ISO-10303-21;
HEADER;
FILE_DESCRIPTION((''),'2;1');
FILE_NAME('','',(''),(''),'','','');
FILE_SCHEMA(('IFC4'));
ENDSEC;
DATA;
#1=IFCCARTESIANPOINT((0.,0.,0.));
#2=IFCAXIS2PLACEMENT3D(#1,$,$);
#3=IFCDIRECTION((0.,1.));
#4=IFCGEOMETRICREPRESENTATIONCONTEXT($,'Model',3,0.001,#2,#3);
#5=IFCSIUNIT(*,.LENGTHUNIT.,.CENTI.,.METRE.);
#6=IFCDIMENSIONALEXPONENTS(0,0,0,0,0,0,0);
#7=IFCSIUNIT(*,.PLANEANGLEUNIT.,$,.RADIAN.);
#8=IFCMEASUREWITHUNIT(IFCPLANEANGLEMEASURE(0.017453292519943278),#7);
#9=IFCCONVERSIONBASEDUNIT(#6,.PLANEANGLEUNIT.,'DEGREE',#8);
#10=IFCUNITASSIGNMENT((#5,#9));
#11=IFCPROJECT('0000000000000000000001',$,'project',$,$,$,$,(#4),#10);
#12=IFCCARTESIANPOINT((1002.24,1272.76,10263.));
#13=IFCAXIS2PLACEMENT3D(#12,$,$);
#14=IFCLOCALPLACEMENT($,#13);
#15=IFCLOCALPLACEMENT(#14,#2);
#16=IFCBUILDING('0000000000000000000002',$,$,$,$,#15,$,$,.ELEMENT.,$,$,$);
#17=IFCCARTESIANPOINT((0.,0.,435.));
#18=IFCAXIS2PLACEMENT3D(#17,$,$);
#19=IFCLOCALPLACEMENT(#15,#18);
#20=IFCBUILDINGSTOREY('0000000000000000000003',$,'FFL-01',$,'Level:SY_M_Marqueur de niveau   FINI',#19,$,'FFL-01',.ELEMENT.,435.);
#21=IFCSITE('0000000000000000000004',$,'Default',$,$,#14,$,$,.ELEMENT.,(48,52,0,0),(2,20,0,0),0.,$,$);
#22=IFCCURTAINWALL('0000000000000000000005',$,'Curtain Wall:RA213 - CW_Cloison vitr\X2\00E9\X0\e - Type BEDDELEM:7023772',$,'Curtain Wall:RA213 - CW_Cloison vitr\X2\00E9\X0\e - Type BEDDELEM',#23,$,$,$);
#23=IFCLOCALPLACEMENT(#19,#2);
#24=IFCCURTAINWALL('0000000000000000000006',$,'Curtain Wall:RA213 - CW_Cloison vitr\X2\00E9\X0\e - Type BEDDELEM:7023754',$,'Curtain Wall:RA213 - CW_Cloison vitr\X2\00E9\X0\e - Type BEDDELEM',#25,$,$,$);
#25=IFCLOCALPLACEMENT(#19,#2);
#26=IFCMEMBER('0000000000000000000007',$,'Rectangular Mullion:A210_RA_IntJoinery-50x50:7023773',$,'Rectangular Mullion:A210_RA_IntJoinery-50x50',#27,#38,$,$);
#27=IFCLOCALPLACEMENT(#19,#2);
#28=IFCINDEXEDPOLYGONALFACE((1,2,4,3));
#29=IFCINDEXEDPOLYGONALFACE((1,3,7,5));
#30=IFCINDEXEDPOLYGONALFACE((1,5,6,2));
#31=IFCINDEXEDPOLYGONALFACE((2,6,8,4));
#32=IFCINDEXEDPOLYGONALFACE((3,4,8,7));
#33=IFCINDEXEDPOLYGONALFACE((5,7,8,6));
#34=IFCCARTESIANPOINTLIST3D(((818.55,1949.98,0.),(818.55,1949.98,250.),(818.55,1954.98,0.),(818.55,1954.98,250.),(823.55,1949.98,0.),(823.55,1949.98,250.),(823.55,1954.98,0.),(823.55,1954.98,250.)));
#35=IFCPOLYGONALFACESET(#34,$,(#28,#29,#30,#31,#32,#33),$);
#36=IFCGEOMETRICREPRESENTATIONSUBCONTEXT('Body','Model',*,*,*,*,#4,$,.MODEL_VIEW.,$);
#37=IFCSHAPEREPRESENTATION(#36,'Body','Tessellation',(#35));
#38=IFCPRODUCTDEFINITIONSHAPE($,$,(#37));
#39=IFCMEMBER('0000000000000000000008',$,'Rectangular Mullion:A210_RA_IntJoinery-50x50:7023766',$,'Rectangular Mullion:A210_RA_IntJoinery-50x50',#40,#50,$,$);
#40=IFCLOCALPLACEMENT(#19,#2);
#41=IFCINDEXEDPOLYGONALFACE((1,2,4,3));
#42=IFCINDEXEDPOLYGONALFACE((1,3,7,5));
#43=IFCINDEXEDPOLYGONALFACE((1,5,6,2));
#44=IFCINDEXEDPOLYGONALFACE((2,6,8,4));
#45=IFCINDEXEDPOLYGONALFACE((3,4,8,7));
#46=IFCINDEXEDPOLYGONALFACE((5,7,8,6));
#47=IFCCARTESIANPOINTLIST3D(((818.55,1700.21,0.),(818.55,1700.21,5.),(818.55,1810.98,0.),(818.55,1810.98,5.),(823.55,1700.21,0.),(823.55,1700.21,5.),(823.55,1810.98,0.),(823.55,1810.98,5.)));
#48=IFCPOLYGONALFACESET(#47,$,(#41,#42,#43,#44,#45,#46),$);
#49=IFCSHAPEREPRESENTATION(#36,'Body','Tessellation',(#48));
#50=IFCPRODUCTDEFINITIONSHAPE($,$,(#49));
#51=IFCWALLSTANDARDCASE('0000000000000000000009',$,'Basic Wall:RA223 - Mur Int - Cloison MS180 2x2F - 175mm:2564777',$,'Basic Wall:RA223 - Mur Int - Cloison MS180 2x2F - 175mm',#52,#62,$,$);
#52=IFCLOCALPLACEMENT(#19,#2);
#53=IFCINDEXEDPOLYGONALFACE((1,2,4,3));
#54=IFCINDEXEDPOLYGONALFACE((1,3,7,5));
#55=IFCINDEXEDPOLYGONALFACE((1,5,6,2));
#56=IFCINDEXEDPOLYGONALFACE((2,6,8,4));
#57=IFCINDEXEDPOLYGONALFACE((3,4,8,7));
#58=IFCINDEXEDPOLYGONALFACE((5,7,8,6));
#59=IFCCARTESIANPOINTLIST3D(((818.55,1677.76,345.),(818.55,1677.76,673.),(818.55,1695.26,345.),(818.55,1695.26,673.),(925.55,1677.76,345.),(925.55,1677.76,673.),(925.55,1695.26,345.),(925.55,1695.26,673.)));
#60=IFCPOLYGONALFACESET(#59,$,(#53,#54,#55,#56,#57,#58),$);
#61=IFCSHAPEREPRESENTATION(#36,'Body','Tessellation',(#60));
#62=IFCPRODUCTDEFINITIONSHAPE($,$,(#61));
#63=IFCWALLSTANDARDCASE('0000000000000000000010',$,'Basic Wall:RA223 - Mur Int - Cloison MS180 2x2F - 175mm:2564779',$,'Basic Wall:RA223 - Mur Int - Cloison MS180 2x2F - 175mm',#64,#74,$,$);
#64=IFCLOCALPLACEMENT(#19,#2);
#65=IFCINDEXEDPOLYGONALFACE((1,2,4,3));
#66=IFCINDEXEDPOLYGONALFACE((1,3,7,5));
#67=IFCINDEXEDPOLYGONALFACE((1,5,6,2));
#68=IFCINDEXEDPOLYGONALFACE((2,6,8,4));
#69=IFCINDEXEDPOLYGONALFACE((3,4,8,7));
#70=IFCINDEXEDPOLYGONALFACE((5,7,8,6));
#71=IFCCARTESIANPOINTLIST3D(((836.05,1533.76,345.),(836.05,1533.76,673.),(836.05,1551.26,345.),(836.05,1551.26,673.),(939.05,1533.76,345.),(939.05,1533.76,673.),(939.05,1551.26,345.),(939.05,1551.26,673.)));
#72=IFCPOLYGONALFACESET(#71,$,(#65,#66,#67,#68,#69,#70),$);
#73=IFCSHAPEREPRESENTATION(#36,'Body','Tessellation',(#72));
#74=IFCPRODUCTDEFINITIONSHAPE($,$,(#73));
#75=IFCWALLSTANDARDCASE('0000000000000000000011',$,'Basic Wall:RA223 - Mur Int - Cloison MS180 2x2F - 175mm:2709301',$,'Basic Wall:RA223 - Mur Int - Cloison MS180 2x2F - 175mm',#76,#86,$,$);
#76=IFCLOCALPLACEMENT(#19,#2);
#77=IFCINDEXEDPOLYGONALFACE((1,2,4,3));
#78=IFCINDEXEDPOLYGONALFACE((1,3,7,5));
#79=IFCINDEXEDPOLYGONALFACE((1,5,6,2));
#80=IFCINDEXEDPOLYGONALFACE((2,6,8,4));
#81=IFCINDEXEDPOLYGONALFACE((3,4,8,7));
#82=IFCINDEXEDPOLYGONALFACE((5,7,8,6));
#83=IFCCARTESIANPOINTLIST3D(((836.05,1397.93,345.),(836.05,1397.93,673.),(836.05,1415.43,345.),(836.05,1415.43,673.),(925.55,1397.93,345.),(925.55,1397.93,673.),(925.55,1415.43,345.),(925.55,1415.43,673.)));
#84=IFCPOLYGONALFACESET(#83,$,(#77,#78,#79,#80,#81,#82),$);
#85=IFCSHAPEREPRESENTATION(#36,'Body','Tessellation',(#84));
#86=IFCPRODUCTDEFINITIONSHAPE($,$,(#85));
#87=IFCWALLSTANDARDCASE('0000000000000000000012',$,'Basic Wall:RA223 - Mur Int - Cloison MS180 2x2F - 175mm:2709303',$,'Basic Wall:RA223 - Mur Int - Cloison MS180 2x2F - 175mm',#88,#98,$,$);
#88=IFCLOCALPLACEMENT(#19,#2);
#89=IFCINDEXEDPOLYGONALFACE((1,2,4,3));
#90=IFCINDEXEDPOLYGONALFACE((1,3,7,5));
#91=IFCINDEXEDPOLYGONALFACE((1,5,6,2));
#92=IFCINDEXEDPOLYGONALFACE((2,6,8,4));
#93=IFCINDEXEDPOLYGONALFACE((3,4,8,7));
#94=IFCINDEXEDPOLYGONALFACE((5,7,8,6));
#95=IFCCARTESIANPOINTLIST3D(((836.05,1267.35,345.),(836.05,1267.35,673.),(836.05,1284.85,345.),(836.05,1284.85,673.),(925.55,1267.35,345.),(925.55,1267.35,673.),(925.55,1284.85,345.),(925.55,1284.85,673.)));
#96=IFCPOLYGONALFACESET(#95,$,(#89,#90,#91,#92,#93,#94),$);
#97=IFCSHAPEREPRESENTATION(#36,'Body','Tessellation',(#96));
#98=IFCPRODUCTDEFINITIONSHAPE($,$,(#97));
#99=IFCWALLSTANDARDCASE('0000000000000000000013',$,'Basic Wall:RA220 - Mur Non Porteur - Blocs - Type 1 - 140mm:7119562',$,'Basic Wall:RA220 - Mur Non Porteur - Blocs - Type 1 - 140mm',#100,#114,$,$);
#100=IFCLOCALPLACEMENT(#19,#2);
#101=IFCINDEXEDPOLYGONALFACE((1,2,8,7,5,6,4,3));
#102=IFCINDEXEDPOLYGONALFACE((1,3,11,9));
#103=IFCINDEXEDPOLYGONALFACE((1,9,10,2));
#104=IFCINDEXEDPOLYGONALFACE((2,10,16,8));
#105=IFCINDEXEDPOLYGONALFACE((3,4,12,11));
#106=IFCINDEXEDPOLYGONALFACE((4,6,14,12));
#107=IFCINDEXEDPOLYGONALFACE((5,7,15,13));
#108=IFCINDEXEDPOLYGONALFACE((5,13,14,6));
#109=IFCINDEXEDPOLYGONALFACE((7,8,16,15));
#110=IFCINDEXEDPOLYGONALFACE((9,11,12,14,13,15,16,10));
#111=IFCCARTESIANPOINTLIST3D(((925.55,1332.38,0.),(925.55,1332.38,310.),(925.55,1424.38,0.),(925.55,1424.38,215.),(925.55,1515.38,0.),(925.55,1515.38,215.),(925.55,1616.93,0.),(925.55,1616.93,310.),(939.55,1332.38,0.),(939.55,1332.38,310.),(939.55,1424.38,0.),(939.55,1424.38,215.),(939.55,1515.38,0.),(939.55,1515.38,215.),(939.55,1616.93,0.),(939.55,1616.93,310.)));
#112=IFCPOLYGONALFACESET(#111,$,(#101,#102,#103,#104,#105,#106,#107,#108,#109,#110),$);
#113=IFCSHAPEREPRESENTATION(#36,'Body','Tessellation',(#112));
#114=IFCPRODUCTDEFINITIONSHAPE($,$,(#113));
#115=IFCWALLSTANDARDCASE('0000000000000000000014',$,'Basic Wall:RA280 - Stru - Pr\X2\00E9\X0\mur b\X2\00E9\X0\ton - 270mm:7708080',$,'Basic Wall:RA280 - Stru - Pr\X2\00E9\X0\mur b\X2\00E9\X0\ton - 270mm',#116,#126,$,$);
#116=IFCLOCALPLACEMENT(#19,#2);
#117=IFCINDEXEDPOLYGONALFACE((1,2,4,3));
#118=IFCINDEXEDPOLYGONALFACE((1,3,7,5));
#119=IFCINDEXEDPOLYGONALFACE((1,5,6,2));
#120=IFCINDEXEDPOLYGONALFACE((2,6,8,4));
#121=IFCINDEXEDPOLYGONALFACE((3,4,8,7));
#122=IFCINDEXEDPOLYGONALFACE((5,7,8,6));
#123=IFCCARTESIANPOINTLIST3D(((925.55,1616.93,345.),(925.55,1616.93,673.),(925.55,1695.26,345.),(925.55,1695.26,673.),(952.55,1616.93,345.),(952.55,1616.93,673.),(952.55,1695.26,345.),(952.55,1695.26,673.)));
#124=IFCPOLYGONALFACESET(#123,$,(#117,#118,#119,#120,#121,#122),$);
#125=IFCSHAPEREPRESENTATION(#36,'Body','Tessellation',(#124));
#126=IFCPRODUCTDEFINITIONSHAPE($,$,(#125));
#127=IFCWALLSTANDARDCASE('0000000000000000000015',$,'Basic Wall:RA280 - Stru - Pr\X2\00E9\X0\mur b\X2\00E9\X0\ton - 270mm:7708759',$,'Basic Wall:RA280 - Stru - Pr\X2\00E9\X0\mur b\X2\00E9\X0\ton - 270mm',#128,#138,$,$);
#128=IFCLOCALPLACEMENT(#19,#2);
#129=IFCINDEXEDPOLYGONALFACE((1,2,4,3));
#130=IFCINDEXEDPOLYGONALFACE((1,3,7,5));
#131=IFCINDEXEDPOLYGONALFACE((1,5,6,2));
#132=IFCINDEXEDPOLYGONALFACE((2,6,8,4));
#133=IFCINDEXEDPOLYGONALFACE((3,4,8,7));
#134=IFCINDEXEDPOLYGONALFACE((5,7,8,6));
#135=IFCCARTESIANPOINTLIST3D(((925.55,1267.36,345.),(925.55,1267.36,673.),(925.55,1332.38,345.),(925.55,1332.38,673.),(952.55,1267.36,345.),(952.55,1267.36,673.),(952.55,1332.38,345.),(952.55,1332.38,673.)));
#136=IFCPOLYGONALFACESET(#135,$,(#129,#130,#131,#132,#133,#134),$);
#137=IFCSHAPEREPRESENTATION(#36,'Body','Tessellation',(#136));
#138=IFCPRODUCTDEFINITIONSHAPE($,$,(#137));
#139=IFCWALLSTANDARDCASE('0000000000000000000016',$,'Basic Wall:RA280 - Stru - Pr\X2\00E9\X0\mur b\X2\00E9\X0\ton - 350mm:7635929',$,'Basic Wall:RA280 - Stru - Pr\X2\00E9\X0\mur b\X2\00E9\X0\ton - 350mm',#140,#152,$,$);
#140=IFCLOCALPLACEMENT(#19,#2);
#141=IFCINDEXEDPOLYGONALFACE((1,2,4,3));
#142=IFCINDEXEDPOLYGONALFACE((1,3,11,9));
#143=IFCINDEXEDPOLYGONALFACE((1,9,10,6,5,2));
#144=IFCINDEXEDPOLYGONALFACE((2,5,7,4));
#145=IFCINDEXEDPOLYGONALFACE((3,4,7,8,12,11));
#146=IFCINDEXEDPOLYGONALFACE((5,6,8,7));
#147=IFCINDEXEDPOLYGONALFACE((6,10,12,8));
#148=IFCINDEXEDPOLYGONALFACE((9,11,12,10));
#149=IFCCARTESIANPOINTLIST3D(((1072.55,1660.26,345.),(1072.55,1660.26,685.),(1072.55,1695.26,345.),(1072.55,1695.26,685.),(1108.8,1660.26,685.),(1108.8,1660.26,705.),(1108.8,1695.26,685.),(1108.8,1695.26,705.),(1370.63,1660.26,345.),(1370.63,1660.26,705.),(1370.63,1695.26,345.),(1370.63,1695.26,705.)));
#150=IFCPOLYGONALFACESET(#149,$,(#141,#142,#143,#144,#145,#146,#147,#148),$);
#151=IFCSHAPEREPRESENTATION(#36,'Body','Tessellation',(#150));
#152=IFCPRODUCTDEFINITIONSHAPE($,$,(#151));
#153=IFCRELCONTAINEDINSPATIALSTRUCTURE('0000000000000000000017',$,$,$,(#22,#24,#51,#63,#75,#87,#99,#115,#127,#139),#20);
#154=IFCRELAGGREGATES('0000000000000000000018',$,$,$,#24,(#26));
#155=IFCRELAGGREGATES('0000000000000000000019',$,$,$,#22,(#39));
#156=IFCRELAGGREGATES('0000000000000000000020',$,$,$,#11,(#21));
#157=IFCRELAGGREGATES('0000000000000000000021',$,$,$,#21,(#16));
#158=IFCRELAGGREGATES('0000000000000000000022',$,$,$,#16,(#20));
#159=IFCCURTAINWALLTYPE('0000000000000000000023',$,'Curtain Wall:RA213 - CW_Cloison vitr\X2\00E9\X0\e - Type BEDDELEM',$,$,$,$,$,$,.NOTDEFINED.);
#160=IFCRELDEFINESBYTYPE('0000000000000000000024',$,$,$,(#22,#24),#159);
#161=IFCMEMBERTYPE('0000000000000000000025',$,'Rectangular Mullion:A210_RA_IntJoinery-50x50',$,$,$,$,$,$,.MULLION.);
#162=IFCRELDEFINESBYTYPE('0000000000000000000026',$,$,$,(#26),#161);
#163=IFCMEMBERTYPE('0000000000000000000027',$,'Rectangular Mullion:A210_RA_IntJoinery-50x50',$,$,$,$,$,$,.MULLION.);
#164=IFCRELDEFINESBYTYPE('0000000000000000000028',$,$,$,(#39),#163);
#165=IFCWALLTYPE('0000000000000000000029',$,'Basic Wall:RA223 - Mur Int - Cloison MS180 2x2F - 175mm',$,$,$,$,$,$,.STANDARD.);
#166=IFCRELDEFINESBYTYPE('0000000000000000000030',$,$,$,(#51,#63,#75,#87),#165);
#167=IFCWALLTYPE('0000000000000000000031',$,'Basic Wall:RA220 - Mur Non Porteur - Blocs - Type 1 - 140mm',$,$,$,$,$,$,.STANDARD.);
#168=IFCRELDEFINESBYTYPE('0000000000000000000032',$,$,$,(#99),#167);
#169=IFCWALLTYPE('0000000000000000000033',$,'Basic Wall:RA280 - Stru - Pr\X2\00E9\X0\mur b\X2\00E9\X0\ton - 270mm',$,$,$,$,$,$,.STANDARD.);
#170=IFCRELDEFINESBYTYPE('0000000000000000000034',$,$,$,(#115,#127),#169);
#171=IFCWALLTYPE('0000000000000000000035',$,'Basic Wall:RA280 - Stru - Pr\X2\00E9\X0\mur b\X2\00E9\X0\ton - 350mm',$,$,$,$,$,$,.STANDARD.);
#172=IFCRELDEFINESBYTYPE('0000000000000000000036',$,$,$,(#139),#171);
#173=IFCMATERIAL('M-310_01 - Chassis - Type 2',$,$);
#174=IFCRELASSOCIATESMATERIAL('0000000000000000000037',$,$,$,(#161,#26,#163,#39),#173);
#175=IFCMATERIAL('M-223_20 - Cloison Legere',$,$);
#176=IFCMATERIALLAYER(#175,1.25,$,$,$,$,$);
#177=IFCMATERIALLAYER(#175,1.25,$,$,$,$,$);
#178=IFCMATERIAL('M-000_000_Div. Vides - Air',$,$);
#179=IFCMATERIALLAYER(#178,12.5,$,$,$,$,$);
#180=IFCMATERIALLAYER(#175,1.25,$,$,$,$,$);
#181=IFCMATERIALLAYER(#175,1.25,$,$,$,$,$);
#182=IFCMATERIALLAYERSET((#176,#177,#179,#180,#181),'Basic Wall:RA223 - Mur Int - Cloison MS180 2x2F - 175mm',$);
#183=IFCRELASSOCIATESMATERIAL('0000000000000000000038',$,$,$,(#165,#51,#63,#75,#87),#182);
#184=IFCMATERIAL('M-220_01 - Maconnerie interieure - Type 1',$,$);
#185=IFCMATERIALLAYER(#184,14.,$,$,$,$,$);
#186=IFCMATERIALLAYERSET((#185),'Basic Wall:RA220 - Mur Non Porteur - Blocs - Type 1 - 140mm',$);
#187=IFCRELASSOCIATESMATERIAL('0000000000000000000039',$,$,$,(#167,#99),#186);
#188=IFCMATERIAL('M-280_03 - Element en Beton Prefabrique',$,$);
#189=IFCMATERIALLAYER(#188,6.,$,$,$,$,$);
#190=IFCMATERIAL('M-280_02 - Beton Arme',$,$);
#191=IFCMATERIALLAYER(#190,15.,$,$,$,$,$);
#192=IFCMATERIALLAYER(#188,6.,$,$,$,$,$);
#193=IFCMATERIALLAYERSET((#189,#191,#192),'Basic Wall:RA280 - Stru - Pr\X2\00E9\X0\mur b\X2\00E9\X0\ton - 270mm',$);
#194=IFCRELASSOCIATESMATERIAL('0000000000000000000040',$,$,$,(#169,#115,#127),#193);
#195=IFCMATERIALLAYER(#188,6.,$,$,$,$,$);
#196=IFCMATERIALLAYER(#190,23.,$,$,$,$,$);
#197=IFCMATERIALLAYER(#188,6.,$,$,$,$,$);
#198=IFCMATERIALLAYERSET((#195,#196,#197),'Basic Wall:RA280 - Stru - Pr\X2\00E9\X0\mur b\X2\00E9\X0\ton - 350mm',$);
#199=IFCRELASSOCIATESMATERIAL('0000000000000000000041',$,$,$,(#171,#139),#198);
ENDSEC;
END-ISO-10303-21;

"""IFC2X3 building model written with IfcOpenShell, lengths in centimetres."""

from ifc_helpers import new_model, entity, si_unit, converted_unit, direction, frame, frame_2d, origin, origin_2d_with_axis, place, context, subcontext, project, spatial, polyline, rectangle, extrude, clip, bounded_halfspace, source, transform, mapped, material, layer, layer_set, layer_usage, type_object, type_shapes, element, aggregate, save


model = new_model("IFC2X3")

# Units and contexts
model_context = context("Model", 3, precision=0.001, world=origin(), true_north=direction((0.0, 1.0)))
body_context = subcontext(model_context, "Body", "Model", "MODEL_VIEW")
ifc_project = project(units=[si_unit("LENGTHUNIT", "METRE", prefix="CENTI"), converted_unit("PLANEANGLEUNIT", "DEGREE", entity("IfcPlaneAngleMeasure", 0.017453292519943278), si_unit("PLANEANGLEUNIT", "RADIAN"), dimensions=[0, 0, 0, 0, 0, 0, 0])], contexts=[model_context])

# Site, building, storey
site_placement = place(None, frame((1002.24, 1272.76, 10263.0)))
site = spatial("IfcSite", under=ifc_project, at=site_placement, Name="Default", CompositionType="ELEMENT", RefLatitude=(48, 52, 0, 0), RefLongitude=(2, 20, 0, 0), RefElevation=0.0)
building_placement = place(site_placement, origin())
building = spatial("IfcBuilding", under=site, at=building_placement, CompositionType="ELEMENT")
storey_placement = place(building_placement, frame((0.0, 0.0, 435.0)))
storey = spatial("IfcBuildingStorey", under=building, at=storey_placement, Name="FFL-01", ObjectType="Level:SY_M_Marqueur de niveau   FINI", LongName="FFL-01", CompositionType="ELEMENT", Elevation=435.0)

# Curtain wall
curtain_wall_type_1 = type_object("IfcCurtainWallType", Name="Curtain Wall:RA213 - CW_Cloison vitrée - Type BEDDELEM", PredefinedType="NOTDEFINED")
curtain_wall_1_placement = place(storey_placement, frame((0.0, 0.0, -435.0)))
curtain_wall_1 = element("IfcCurtainWall", 1, at=curtain_wall_1_placement, inside=storey, type_object=curtain_wall_type_1, Name="Curtain Wall:RA213 - CW_Cloison vitrée - Type BEDDELEM:7023772", ObjectType="Curtain Wall:RA213 - CW_Cloison vitrée - Type BEDDELEM")
ifc_material_1 = material(Name="M-310_01 - Chassis - Type 2")

# Shared definitions
ifc_material_2 = material(Name="M-280_02 - Beton Arme")

# Curtain wall, member
curtain_wall_2_placement = place(storey_placement, frame((0.0, 0.0, -435.0)))
curtain_wall_2 = element("IfcCurtainWall", 2, at=curtain_wall_2_placement, inside=storey, type_object=curtain_wall_type_1, Name="Curtain Wall:RA213 - CW_Cloison vitrée - Type BEDDELEM:7023754", ObjectType="Curtain Wall:RA213 - CW_Cloison vitrée - Type BEDDELEM")
member_type_1 = type_object("IfcMemberType", Name="Rectangular Mullion:A210_RA_IntJoinery-50x50", PredefinedType="MULLION", material=ifc_material_1)
shared_shape_1 = source(origin(), body_context, "Body", "SweptSolid", [
    extrude(rectangle(XDim=5.0, YDim=5.0, at=origin_2d_with_axis()), frame((-2.5, -2.5, -250.0), z_axis=(0.0, 0.0, 1.0), x_axis=(-1.0, 0.0, 0.0)), (0.0, 0.0, 1.0), 250.0),
])
type_shapes(member_type_1, [shared_shape_1])
member_1_placement = place(curtain_wall_2_placement, frame((818.55, 1949.98, 435.0), z_axis=(0.0, 0.0, -1.0), x_axis=(0.0, -1.0, 0.0)))
member_1 = element("IfcMember", 3, at=member_1_placement, type_object=member_type_1, material=ifc_material_1, Name="Rectangular Mullion:A210_RA_IntJoinery-50x50:7023773", ObjectType="Rectangular Mullion:A210_RA_IntJoinery-50x50", context=body_context, shape_type="MappedRepresentation", body=[
    mapped(shared_shape_1, transform((0.0, 0.0, 0.0), scale=1.0)),
])
aggregate(curtain_wall_2, [member_1])

# Member
member_type_2 = type_object("IfcMemberType", Name="Rectangular Mullion:A210_RA_IntJoinery-50x50", PredefinedType="MULLION", material=ifc_material_1)
shared_shape_2 = source(origin(), body_context, "Body", "SweptSolid", [
    extrude(rectangle(XDim=5.0, YDim=5.0, at=origin_2d_with_axis()), frame((-2.5, -2.5, -110.77), z_axis=(0.0, 0.0, 1.0), x_axis=(-1.0, 0.0, 0.0)), (0.0, 0.0, 1.0), 110.77),
])
type_shapes(member_type_2, [shared_shape_2])
member_2_placement = place(curtain_wall_1_placement, frame((818.55, 1810.98, 435.0), z_axis=(0.0, 1.0, 0.0), x_axis=(0.0, 0.0, -1.0)))
member_2 = element("IfcMember", 4, at=member_2_placement, type_object=member_type_2, material=ifc_material_1, Name="Rectangular Mullion:A210_RA_IntJoinery-50x50:7023766", ObjectType="Rectangular Mullion:A210_RA_IntJoinery-50x50", context=body_context, shape_type="MappedRepresentation", body=[
    mapped(shared_shape_2, transform((0.0, 0.0, 0.0), scale=1.0)),
])

# Walls
ifc_material_3 = material(Name="M-223_20 - Cloison Legere")
ifc_layer_1 = layer(ifc_material_3, 1.25)
ifc_layer_2 = layer(ifc_material_3, 1.25)
ifc_material_4 = material(Name="M-000_000_Div. Vides - Air")
ifc_layer_3 = layer(ifc_material_4, 12.5)
ifc_layer_4 = layer(ifc_material_3, 1.25)
ifc_layer_5 = layer(ifc_material_3, 1.25)
ifc_layer_set_1 = layer_set([ifc_layer_1, ifc_layer_2, ifc_layer_3, ifc_layer_4, ifc_layer_5], Name="Basic Wall:RA223 - Mur Int - Cloison MS180 2x2F - 175mm")
ifc_layer_usage_1 = layer_usage(ifc_layer_set_1, "AXIS2", "NEGATIVE", 8.75)
wall_type_1 = type_object("IfcWallType", Name="Basic Wall:RA223 - Mur Int - Cloison MS180 2x2F - 175mm", PredefinedType="STANDARD", material=ifc_layer_set_1)
wall_1_placement = place(storey_placement, frame((818.55, 1686.51, 345.0)))
element("IfcWallStandardCase", 5, at=wall_1_placement, inside=storey, type_object=wall_type_1, material=ifc_layer_usage_1, Name="Basic Wall:RA223 - Mur Int - Cloison MS180 2x2F - 175mm:2564777", ObjectType="Basic Wall:RA223 - Mur Int - Cloison MS180 2x2F - 175mm", context=body_context, shape_type="Clipping", body=[
    clip(extrude(rectangle(XDim=106.99, YDim=17.5, at=frame_2d((53.5, 0.0), x_axis=(-1.0, 0.0))), origin(), (0.0, 0.0, 1.0), 328.0), bounded_halfspace(frame((0.0, -8.75, 328.0), z_axis=(0.0, 0.0, -1.0), x_axis=(1.0, 0.0, 0.0)), True, frame((0.0, -8.75, 328.0), z_axis=(0.0, 0.0, -1.0), x_axis=(1.0, 0.0, 0.0)), polyline([(0.0, 0.0), (0.0, -17.5), (106.99, -17.5), (106.99, 0.0), (17.5, 0.0), (0.0, 0.0)]))),
])
ifc_layer_usage_2 = layer_usage(ifc_layer_set_1, "AXIS2", "NEGATIVE", 8.75)
wall_2_placement = place(storey_placement, frame((939.05, 1542.51, 345.0), z_axis=(0.0, 0.0, 1.0), x_axis=(-1.0, 0.0, 0.0)))
element("IfcWallStandardCase", 6, at=wall_2_placement, inside=storey, type_object=wall_type_1, material=ifc_layer_usage_2, Name="Basic Wall:RA223 - Mur Int - Cloison MS180 2x2F - 175mm:2564779", ObjectType="Basic Wall:RA223 - Mur Int - Cloison MS180 2x2F - 175mm", context=body_context, shape_type="Clipping", body=[
    clip(extrude(rectangle(XDim=102.99, YDim=17.5, at=frame_2d((51.5, 0.0), x_axis=(-1.0, 0.0))), origin(), (0.0, 0.0, 1.0), 328.0), bounded_halfspace(frame((0.0, -8.75, 328.0), z_axis=(0.0, 0.0, -1.0), x_axis=(-1.0, 0.0, 0.0)), True, frame((0.0, -8.75, 328.0), z_axis=(0.0, 0.0, -1.0), x_axis=(-1.0, 0.0, 0.0)), polyline([(0.0, 0.0), (0.0, 17.5), (-102.99, 17.5), (-102.99, 0.0), (0.0, 0.0)]))),
])
ifc_layer_usage_3 = layer_usage(ifc_layer_set_1, "AXIS2", "NEGATIVE", 8.75)
wall_3_placement = place(storey_placement, frame((836.05, 1406.68, 345.0)))
element("IfcWallStandardCase", 7, at=wall_3_placement, inside=storey, type_object=wall_type_1, material=ifc_layer_usage_3, Name="Basic Wall:RA223 - Mur Int - Cloison MS180 2x2F - 175mm:2709301", ObjectType="Basic Wall:RA223 - Mur Int - Cloison MS180 2x2F - 175mm", context=body_context, shape_type="Clipping", body=[
    clip(extrude(rectangle(XDim=89.49, YDim=17.5, at=frame_2d((44.75, 0.0), x_axis=(-1.0, 0.0))), origin(), (0.0, 0.0, 1.0), 328.0), bounded_halfspace(frame((0.0, -8.75, 328.0), z_axis=(0.0, 0.0, -1.0), x_axis=(1.0, 0.0, 0.0)), True, frame((0.0, -8.75, 328.0), z_axis=(0.0, 0.0, -1.0), x_axis=(1.0, 0.0, 0.0)), polyline([(0.0, 0.0), (0.0, -17.5), (89.49, -17.5), (89.49, 0.0), (0.0, 0.0)]))),
])
ifc_layer_usage_4 = layer_usage(ifc_layer_set_1, "AXIS2", "NEGATIVE", 8.75)
wall_4_placement = place(storey_placement, frame((925.55, 1276.1, 345.0), z_axis=(0.0, 0.0, 1.0), x_axis=(-1.0, 0.0, 0.0)))
element("IfcWallStandardCase", 8, at=wall_4_placement, inside=storey, type_object=wall_type_1, material=ifc_layer_usage_4, Name="Basic Wall:RA223 - Mur Int - Cloison MS180 2x2F - 175mm:2709303", ObjectType="Basic Wall:RA223 - Mur Int - Cloison MS180 2x2F - 175mm", context=body_context, shape_type="Clipping", body=[
    clip(extrude(rectangle(XDim=89.49, YDim=17.5, at=frame_2d((44.75, 0.0), x_axis=(-1.0, 0.0))), origin(), (0.0, 0.0, 1.0), 328.0), bounded_halfspace(frame((0.0, -8.75, 328.0), z_axis=(0.0, 0.0, -1.0), x_axis=(-1.0, 0.0, 0.0)), True, frame((0.0, -8.75, 328.0), z_axis=(0.0, 0.0, -1.0), x_axis=(-1.0, 0.0, 0.0)), polyline([(0.0, 0.0), (0.0, 17.5), (-89.49, 17.5), (-89.49, 0.0), (0.0, 0.0)]))),
])

# Wall, opening
ifc_material_5 = material(Name="M-220_01 - Maconnerie interieure - Type 1")
ifc_layer_6 = layer(ifc_material_5, 14.0)
ifc_layer_set_2 = layer_set([ifc_layer_6], Name="Basic Wall:RA220 - Mur Non Porteur - Blocs - Type 1 - 140mm")
ifc_layer_usage_5 = layer_usage(ifc_layer_set_2, "AXIS2", "POSITIVE", -7.0)
wall_type_2 = type_object("IfcWallType", Name="Basic Wall:RA220 - Mur Non Porteur - Blocs - Type 1 - 140mm", PredefinedType="STANDARD", material=ifc_layer_set_2)
wall_5_placement = place(storey_placement, frame((932.55, 1616.93, 0.0), z_axis=(0.0, 0.0, 1.0), x_axis=(0.0, -1.0, 0.0)))
wall_5 = element("IfcWallStandardCase", 9, at=wall_5_placement, inside=storey, type_object=wall_type_2, material=ifc_layer_usage_5, Name="Basic Wall:RA220 - Mur Non Porteur - Blocs - Type 1 - 140mm:7119562", ObjectType="Basic Wall:RA220 - Mur Non Porteur - Blocs - Type 1 - 140mm", context=body_context, shape_type="SweptSolid", body=[
    extrude(rectangle(XDim=284.55, YDim=14.0, at=frame_2d((142.27, 0.0), x_axis=(-1.0, 0.0))), origin(), (0.0, 0.0, 1.0), 310.0),
])
opening_placement = place(wall_5_placement, frame((1616.93, -932.55, 0.0), z_axis=(0.0, 0.0, 1.0), x_axis=(0.0, 1.0, 0.0)))
element("IfcOpeningElement", 10, at=opening_placement, cuts=wall_5, ObjectType="Opening", context=body_context, shape_type="SweptSolid", body=[
    extrude(rectangle(XDim=220.0, YDim=91.0, at=frame_2d((0.0, 0.0), x_axis=(1.0, 0.0))), frame((925.55, 1469.88, 105.0), z_axis=(1.0, 0.0, 0.0), x_axis=(0.0, 0.0, -1.0)), (0.0, 0.0, 1.0), 14.0),
])

# Walls
ifc_material_6 = material(Name="M-280_03 - Element en Beton Prefabrique")
ifc_layer_7 = layer(ifc_material_6, 6.0)
ifc_layer_8 = layer(ifc_material_2, 15.0)
ifc_layer_9 = layer(ifc_material_6, 6.0)
ifc_layer_set_3 = layer_set([ifc_layer_7, ifc_layer_8, ifc_layer_9], Name="Basic Wall:RA280 - Stru - Prémur béton - 270mm")
ifc_layer_usage_6 = layer_usage(ifc_layer_set_3, "AXIS2", "NEGATIVE", 13.5)
wall_type_3 = type_object("IfcWallType", Name="Basic Wall:RA280 - Stru - Prémur béton - 270mm", PredefinedType="STANDARD", material=ifc_layer_set_3)
wall_6_placement = place(storey_placement, frame((939.05, 1695.26, 345.0), z_axis=(0.0, 0.0, 1.0), x_axis=(0.0, -1.0, 0.0)))
element("IfcWallStandardCase", 11, at=wall_6_placement, inside=storey, type_object=wall_type_3, material=ifc_layer_usage_6, Name="Basic Wall:RA280 - Stru - Prémur béton - 270mm:7708080", ObjectType="Basic Wall:RA280 - Stru - Prémur béton - 270mm", context=body_context, shape_type="Clipping", body=[
    clip(extrude(rectangle(XDim=78.33, YDim=27.0, at=frame_2d((39.17, 0.0), x_axis=(-1.0, 0.0))), origin(), (0.0, 0.0, 1.0), 328.0), bounded_halfspace(frame((0.0, -13.5, 328.0), z_axis=(0.0, 0.0, -1.0), x_axis=(0.0, 1.0, 0.0)), True, frame((0.0, -13.5, 328.0), z_axis=(0.0, 0.0, -1.0), x_axis=(0.0, 1.0, 0.0)), polyline([(0.0, 0.0), (27.0, 0.0), (27.0, 35.0), (27.0, 78.33), (0.0, 78.33), (0.0, 0.0)]))),
])
ifc_layer_usage_7 = layer_usage(ifc_layer_set_3, "AXIS2", "NEGATIVE", 13.5)
wall_7_placement = place(storey_placement, frame((939.05, 1332.38, 345.0), z_axis=(0.0, 0.0, 1.0), x_axis=(0.0, -1.0, 0.0)))
element("IfcWallStandardCase", 12, at=wall_7_placement, inside=storey, type_object=wall_type_3, material=ifc_layer_usage_7, Name="Basic Wall:RA280 - Stru - Prémur béton - 270mm:7708759", ObjectType="Basic Wall:RA280 - Stru - Prémur béton - 270mm", context=body_context, shape_type="Clipping", body=[
    clip(extrude(rectangle(XDim=65.03, YDim=27.0, at=frame_2d((32.51, 0.0), x_axis=(-1.0, 0.0))), origin(), (0.0, 0.0, 1.0), 328.0), bounded_halfspace(frame((0.0, -13.5, 328.0), z_axis=(0.0, 0.0, -1.0), x_axis=(0.0, 1.0, 0.0)), True, frame((0.0, -13.5, 328.0), z_axis=(0.0, 0.0, -1.0), x_axis=(0.0, 1.0, 0.0)), polyline([(0.0, 0.0), (27.0, 0.0), (27.0, 43.03), (27.0, 65.03), (0.0, 65.03), (0.0, 0.0)]))),
])

aggregate(curtain_wall_1, [member_2])

# Wall
ifc_layer_10 = layer(ifc_material_6, 6.0)
ifc_layer_11 = layer(ifc_material_2, 23.0)
ifc_layer_12 = layer(ifc_material_6, 6.0)
ifc_layer_set_4 = layer_set([ifc_layer_10, ifc_layer_11, ifc_layer_12], Name="Basic Wall:RA280 - Stru - Prémur béton - 350mm")
ifc_layer_usage_8 = layer_usage(ifc_layer_set_4, "AXIS2", "NEGATIVE", 17.5)
wall_type_4 = type_object("IfcWallType", Name="Basic Wall:RA280 - Stru - Prémur béton - 350mm", PredefinedType="STANDARD", material=ifc_layer_set_4)
wall_8_placement = place(storey_placement, frame((1370.63, 1677.76, 345.0), z_axis=(0.0, 0.0, 1.0), x_axis=(-1.0, 0.0, 0.0)))
element("IfcWallStandardCase", 13, at=wall_8_placement, inside=storey, type_object=wall_type_4, material=ifc_layer_usage_8, Name="Basic Wall:RA280 - Stru - Prémur béton - 350mm:7635929", ObjectType="Basic Wall:RA280 - Stru - Prémur béton - 350mm", context=body_context, shape_type="Clipping", body=[
    clip(clip(extrude(rectangle(XDim=298.09, YDim=35.0, at=frame_2d((149.04, 0.0), x_axis=(-1.0, 0.0))), origin(), (0.0, 0.0, 1.0), 360.0), bounded_halfspace(frame((261.83, 17.5, 340.0), z_axis=(0.0, 0.0, -1.0), x_axis=(-0.000007, 1.0, 0.0)), True, frame((261.83, 17.5, 340.0), z_axis=(0.0, 0.0, -1.0), x_axis=(-0.000007, 1.0, 0.0)), polyline([(0.0, 0.0), (0.0, 36.25), (-35.0, 36.25), (-35.0, 14.0), (-35.0, 0.0), (0.0, 0.0)]))), bounded_halfspace(frame((261.83, -17.5, 340.0), z_axis=(-1.0, -0.000007, 0.0), x_axis=(0.0, 0.0, 1.0)), True, frame((261.83, -17.5, 340.0), z_axis=(-1.0, -0.000007, 0.0), x_axis=(0.0, 0.0, 1.0)), polyline([(0.0, 0.0), (20.0, 0.0), (20.0, 35.0), (0.0, 35.0), (0.0, 0.0)]))),
])

save(model, "model.ifc")
